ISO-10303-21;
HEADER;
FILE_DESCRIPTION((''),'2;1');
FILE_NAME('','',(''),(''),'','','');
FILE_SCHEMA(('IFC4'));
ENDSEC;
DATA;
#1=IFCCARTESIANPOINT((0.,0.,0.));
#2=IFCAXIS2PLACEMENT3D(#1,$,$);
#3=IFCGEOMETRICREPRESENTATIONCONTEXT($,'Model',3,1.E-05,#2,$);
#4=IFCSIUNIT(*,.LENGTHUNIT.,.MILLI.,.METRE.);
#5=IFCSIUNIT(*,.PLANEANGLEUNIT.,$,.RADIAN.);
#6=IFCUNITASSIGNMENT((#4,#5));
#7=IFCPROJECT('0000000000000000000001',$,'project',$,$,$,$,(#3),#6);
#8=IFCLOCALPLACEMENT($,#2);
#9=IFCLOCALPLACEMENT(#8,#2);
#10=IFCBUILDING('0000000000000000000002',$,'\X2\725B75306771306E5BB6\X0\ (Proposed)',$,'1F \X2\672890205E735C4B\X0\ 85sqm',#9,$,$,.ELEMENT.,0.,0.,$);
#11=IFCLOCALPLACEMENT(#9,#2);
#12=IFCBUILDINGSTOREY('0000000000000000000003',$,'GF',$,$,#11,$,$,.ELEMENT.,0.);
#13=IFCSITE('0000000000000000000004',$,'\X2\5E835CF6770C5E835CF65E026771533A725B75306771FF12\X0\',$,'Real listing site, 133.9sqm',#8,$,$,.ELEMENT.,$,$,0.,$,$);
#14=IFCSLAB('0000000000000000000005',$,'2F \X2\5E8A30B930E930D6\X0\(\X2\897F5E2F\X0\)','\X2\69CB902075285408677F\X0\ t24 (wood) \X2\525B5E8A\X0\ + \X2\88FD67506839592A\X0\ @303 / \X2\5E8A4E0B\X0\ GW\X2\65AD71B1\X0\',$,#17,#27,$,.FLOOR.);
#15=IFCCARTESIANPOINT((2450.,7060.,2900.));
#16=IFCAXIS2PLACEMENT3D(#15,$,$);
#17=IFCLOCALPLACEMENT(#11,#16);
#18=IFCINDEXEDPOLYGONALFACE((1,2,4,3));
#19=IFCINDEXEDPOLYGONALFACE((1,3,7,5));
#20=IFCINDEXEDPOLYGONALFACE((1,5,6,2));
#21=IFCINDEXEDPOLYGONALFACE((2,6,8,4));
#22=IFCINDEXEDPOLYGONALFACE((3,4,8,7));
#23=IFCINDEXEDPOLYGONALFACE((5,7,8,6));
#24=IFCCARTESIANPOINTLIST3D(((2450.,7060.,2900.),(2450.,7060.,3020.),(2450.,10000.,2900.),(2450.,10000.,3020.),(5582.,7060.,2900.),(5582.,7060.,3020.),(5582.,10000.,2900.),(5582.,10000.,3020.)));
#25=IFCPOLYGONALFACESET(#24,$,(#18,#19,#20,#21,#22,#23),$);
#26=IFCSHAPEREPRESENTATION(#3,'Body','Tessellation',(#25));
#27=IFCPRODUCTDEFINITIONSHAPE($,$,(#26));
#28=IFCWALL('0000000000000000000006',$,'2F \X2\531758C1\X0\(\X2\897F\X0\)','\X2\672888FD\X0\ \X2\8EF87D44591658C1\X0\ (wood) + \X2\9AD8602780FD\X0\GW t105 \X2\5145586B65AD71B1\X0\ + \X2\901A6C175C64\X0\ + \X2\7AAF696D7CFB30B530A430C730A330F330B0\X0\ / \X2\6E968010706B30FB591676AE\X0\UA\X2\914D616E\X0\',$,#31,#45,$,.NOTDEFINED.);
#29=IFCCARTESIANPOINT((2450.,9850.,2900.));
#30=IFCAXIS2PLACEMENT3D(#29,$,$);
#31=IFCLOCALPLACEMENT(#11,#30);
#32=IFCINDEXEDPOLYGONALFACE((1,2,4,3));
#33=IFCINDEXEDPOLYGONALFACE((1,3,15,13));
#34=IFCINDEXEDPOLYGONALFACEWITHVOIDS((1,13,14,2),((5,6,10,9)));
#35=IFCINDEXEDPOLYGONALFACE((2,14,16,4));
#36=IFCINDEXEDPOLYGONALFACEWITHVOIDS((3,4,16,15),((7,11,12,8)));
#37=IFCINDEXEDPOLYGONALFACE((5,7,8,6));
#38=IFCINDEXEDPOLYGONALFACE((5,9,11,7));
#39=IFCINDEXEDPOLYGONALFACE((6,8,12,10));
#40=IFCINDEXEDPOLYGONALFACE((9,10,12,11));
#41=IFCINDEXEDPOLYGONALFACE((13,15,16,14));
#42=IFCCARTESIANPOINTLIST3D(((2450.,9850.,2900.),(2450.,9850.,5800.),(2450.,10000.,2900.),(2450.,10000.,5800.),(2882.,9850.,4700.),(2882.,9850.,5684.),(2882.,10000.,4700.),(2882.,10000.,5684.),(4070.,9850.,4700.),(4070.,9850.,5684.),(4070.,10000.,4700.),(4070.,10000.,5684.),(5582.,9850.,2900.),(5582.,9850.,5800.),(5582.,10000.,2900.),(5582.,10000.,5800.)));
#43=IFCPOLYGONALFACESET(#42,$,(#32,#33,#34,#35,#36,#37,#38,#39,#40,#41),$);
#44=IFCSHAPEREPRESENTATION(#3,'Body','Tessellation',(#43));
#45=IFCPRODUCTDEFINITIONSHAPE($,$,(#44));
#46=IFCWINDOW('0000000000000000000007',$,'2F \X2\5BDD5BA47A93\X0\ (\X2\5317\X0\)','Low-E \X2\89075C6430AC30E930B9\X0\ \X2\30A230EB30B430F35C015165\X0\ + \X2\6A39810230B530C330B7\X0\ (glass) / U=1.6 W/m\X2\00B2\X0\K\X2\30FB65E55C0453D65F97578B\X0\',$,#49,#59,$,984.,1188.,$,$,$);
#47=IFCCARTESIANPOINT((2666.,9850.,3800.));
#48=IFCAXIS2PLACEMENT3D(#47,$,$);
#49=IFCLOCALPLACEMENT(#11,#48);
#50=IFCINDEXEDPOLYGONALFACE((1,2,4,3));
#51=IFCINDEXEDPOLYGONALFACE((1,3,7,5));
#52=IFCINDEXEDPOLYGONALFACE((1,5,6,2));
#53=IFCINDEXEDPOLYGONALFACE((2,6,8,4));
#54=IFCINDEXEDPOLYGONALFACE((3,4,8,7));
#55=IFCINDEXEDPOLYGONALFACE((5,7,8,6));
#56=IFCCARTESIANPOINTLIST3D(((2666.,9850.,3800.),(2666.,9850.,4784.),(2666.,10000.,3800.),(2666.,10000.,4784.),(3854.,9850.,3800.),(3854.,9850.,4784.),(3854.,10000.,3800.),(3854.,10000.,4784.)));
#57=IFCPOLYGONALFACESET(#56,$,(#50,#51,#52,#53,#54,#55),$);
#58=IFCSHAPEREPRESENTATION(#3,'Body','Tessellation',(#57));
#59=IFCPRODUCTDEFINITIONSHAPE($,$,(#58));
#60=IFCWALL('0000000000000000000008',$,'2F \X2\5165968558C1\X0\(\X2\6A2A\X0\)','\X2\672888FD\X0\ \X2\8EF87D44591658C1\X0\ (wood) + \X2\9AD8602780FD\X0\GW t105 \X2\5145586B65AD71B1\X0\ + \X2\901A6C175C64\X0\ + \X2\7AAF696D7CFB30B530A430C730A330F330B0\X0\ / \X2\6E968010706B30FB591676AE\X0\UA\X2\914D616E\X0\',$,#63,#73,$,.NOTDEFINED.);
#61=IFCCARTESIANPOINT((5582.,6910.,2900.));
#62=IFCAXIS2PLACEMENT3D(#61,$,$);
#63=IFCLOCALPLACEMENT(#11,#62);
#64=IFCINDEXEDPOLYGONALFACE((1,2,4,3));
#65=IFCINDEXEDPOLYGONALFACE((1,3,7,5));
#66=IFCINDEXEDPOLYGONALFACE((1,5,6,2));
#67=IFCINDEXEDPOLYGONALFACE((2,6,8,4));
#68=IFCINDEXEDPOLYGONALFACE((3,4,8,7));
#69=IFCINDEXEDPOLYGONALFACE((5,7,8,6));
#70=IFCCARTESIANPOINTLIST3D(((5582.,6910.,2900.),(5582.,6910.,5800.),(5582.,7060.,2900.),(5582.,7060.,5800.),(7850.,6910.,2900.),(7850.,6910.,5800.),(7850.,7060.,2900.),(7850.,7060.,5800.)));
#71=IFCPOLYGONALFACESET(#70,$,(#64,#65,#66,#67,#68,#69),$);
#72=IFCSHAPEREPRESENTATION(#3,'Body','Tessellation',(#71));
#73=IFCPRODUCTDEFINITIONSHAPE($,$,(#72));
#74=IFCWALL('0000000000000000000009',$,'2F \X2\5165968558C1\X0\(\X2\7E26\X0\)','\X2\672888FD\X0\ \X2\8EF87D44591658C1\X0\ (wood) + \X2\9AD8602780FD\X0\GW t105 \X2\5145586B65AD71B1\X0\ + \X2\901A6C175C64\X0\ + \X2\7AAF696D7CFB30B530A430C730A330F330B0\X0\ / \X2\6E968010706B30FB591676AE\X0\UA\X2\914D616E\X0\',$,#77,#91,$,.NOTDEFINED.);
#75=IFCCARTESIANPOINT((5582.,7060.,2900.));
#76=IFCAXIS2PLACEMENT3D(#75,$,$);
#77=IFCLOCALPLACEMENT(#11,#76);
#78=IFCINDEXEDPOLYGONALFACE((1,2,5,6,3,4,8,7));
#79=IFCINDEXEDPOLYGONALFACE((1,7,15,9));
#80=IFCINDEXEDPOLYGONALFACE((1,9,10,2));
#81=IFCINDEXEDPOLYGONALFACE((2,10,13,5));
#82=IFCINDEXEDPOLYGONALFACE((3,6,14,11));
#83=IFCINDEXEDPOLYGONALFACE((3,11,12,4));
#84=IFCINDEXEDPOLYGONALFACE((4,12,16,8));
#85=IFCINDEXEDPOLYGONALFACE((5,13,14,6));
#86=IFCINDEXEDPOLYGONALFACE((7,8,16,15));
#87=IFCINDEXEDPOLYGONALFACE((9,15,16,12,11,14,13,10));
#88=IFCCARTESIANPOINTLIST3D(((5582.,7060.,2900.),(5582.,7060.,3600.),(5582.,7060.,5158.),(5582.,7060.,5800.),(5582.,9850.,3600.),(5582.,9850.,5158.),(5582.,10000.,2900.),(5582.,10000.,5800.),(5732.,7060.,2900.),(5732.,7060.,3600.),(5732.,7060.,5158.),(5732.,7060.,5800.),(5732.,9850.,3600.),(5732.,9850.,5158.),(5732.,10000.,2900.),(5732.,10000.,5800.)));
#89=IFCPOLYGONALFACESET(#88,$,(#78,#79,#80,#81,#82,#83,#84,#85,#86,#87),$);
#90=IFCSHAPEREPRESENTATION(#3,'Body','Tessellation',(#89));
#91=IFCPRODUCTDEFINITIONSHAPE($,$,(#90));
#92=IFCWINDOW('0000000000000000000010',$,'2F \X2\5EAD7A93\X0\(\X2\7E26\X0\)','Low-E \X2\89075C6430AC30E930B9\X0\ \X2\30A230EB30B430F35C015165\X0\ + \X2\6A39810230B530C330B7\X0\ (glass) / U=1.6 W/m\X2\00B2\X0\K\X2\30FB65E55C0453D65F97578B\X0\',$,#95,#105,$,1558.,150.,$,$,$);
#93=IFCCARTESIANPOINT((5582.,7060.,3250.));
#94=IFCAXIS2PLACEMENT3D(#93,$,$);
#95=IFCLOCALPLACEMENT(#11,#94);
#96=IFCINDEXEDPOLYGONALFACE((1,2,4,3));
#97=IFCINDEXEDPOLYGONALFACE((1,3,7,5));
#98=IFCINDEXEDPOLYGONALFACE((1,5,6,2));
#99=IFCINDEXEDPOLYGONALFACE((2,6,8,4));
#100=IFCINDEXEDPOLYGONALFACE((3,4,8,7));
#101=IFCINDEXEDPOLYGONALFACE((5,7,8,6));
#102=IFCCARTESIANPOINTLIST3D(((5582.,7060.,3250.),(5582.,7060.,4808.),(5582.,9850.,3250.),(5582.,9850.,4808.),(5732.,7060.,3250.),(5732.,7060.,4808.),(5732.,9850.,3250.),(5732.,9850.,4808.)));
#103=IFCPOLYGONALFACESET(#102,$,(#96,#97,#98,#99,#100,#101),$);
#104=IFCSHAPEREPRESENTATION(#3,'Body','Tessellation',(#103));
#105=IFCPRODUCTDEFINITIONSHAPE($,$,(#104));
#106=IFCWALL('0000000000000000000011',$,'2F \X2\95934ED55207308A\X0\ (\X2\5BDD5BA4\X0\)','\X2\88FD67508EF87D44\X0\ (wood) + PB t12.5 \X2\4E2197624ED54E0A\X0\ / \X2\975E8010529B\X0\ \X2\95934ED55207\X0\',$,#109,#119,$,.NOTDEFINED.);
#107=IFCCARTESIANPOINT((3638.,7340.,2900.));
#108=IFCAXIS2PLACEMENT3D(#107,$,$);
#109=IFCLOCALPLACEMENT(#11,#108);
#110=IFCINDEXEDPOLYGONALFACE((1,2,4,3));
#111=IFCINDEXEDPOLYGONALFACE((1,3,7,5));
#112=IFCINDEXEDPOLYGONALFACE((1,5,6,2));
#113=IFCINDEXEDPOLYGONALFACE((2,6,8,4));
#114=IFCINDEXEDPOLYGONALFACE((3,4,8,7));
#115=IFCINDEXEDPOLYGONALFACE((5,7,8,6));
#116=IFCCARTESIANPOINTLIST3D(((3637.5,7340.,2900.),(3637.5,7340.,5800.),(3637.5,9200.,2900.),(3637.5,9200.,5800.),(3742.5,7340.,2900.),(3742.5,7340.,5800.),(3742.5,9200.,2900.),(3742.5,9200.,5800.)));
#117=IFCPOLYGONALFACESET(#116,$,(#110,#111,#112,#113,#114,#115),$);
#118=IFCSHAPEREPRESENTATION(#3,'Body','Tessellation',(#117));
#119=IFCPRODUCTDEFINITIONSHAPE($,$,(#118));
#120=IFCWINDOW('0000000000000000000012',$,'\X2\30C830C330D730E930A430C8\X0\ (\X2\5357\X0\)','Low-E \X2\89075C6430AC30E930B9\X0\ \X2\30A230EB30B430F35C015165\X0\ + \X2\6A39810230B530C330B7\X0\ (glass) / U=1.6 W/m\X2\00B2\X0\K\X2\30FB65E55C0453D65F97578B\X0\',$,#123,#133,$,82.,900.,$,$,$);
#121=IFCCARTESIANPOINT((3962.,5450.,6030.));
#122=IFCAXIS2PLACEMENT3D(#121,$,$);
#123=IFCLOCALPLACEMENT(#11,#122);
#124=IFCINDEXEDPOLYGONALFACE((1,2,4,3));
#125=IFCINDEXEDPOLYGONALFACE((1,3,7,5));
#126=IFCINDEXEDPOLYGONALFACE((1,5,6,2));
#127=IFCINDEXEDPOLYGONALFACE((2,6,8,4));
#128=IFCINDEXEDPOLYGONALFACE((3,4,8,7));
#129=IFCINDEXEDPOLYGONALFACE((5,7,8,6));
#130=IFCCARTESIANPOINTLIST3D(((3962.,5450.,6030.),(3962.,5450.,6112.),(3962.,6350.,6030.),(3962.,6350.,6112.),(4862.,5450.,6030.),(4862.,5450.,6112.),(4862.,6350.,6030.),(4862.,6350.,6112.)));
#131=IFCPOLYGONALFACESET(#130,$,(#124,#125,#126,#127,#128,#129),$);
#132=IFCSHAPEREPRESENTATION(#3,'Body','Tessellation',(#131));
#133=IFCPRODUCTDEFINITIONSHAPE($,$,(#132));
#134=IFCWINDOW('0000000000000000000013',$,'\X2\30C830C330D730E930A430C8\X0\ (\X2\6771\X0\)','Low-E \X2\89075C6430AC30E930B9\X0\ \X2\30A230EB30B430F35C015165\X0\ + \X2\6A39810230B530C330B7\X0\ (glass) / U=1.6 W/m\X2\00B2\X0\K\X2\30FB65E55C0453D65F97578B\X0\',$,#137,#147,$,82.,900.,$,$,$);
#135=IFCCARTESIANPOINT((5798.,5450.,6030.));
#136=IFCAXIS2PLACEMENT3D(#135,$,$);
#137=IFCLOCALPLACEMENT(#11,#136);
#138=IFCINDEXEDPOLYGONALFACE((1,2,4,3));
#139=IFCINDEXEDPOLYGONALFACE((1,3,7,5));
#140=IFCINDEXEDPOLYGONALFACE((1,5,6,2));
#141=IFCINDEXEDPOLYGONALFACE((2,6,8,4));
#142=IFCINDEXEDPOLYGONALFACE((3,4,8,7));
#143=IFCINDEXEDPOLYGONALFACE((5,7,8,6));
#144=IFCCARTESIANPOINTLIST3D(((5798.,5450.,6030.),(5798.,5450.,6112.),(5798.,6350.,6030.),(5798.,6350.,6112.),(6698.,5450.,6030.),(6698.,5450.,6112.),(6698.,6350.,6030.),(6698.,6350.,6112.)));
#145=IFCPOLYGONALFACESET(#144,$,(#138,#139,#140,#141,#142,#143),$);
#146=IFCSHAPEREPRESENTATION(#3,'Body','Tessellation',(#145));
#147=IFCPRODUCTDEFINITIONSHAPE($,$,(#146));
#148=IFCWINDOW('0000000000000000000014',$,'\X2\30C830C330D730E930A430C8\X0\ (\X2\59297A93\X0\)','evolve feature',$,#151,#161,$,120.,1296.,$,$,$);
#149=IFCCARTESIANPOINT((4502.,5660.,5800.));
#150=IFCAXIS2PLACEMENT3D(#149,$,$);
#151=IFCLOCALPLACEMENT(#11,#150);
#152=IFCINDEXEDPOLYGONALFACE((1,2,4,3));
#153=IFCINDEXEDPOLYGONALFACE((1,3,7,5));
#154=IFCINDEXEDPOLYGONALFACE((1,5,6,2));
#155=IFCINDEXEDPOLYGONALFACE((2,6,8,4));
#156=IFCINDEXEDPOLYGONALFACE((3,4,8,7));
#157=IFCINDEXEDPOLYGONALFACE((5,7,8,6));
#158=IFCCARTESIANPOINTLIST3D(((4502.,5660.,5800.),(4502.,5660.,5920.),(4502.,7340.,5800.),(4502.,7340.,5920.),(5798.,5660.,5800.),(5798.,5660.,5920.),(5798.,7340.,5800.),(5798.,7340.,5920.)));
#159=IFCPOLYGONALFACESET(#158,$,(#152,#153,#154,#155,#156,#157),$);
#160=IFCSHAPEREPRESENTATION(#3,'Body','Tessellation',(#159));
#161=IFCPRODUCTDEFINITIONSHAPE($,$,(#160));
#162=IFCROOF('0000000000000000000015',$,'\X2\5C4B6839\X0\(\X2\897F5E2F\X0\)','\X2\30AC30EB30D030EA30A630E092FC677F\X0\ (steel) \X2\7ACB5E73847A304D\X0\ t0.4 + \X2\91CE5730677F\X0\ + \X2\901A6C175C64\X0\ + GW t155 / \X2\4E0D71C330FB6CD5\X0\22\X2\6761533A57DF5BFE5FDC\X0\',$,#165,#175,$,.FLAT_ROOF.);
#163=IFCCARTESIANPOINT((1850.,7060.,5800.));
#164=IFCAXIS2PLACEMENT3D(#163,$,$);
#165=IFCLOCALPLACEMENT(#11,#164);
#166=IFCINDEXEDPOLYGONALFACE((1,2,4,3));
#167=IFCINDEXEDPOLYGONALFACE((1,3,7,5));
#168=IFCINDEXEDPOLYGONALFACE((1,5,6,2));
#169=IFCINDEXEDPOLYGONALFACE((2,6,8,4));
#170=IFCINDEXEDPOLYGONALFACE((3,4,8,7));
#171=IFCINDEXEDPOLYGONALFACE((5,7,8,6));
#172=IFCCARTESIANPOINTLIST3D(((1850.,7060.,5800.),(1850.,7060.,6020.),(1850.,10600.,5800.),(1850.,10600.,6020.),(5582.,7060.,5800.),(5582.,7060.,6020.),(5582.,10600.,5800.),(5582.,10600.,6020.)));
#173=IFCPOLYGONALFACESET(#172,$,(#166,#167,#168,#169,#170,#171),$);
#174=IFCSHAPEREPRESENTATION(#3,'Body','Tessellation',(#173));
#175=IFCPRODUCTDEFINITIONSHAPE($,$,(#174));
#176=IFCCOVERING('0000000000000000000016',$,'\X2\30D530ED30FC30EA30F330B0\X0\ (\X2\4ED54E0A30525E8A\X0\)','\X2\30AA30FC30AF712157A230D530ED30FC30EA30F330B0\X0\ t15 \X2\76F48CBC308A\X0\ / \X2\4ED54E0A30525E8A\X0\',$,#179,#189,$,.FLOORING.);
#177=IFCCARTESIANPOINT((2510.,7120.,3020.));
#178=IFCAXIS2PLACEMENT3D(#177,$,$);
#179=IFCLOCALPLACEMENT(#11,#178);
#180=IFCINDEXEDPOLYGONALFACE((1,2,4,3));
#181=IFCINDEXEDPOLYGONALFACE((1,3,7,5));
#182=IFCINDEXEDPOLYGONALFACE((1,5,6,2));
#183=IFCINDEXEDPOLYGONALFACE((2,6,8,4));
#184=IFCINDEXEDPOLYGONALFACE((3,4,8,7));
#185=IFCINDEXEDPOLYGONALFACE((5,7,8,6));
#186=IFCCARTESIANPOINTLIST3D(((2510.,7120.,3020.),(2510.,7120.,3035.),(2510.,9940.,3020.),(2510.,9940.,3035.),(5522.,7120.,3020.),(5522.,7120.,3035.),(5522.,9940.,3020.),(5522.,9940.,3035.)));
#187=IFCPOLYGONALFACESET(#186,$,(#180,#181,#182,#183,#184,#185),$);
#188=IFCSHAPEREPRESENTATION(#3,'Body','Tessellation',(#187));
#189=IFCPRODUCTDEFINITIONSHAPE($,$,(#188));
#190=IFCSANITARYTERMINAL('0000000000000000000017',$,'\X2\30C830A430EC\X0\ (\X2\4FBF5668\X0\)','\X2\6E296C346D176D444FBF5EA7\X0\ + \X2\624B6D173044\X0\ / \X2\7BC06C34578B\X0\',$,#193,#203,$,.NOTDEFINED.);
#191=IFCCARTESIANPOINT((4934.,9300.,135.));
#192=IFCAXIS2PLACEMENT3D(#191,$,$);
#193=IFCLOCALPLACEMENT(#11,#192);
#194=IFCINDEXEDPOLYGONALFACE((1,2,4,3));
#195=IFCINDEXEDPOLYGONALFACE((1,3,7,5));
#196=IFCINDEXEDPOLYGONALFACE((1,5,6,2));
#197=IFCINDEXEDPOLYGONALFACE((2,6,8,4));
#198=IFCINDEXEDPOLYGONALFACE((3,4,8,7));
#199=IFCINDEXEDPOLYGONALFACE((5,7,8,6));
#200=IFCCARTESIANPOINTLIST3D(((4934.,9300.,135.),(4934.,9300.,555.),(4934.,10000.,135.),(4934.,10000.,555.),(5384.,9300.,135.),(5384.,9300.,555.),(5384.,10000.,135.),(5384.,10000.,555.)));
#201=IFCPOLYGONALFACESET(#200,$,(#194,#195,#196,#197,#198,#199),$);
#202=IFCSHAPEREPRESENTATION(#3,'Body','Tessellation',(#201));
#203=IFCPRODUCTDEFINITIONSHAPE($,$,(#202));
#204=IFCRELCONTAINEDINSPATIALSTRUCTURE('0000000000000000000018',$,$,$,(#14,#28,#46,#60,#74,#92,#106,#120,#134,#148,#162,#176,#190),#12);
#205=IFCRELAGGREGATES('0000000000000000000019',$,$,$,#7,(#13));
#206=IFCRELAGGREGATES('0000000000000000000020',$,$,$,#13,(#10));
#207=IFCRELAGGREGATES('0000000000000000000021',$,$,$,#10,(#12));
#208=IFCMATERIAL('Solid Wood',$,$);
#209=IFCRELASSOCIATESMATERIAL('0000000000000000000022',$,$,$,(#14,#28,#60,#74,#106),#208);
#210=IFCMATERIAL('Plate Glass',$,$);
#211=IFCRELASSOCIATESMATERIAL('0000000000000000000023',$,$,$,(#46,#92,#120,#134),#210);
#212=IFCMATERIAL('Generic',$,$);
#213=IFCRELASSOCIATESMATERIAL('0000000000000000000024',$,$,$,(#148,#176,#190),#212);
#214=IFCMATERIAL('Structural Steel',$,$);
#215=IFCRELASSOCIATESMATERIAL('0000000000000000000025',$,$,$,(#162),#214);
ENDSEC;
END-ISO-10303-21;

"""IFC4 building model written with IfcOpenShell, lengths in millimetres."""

from ifc_helpers import new_model, si_unit, frame, frame_2d, origin, place, context, project, spatial, rectangle, extrude, material, element, fill, save


model = new_model("IFC4")

# Units and contexts
model_context = context("Model", 3, precision=1e-05, world=origin())
ifc_project = project(units=[si_unit("LENGTHUNIT", "METRE", prefix="MILLI"), si_unit("PLANEANGLEUNIT", "RADIAN")], contexts=[model_context])

# Site, building, storey
site_placement = place(None, origin())
site = spatial("IfcSite", under=ifc_project, at=site_placement, Name="広島県広島市東区牛田東２", ObjectType="Real listing site, 133.9sqm", CompositionType="ELEMENT", RefElevation=0.0)
building_placement = place(site_placement, origin())
building = spatial("IfcBuilding", under=site, at=building_placement, Name="牛田東の家 (Proposed)", ObjectType="1F 木造平屋 85sqm", CompositionType="ELEMENT", ElevationOfRefHeight=0.0, ElevationOfTerrain=0.0)
storey_placement = place(building_placement, origin())
storey = spatial("IfcBuildingStorey", under=building, at=storey_placement, Name="GF", CompositionType="ELEMENT", Elevation=0.0)

# Slab
ifc_material_1 = material(Name="Solid Wood")
slab_placement = place(storey_placement, frame((2450.0, 7060.0, 2900.0)))
element("IfcSlab", 1, at=slab_placement, inside=storey, material=ifc_material_1, Name="2F 床スラブ(西帯)", Description="構造用合板 t24 (wood) 剛床 + 製材根太 @303 / 床下 GW断熱", PredefinedType="FLOOR", context=model_context, shape_type="SweptSolid", body=[
    extrude(rectangle(XDim=3132.0, YDim=2940.0, at=frame_2d((1566.0, 1470.0))), frame((2450.0, 7060.0, 2900.0)), (0.0, 0.0, 1.0), 120.0),
])

# Wall, opening, window
wall_1_placement = place(storey_placement, frame((2450.0, 9850.0, 2900.0)))
wall_1 = element("IfcWall", 2, at=wall_1_placement, inside=storey, material=ifc_material_1, Name="2F 北壁(西)", Description="木製 軸組外壁 (wood) + 高性能GW t105 充填断熱 + 通気層 + 窯業系サイディング / 準耐火・外皮UA配慮", PredefinedType="NOTDEFINED", context=model_context, shape_type="SweptSolid", body=[
    extrude(rectangle(XDim=3132.0, YDim=150.0, at=frame_2d((1566.0, 75.0))), frame((2450.0, 9850.0, 2900.0)), (0.0, 0.0, 1.0), 2900.0),
])
opening_1_placement = place(storey_placement, frame((2666.0, 9850.0, 3800.0)))
opening_1 = element("IfcOpeningElement", 3, at=opening_1_placement, cuts=wall_1, PredefinedType="NOTDEFINED", context=model_context, shape_type="SweptSolid", body=[
    extrude(rectangle(XDim=1188.0, YDim=150.0, at=frame_2d((594.0, 75.0))), frame((2666.0, 9850.0, 3800.0)), (0.0, 0.0, 1.0), 984.0),
])
ifc_material_2 = material(Name="Plate Glass")
window_1_placement = place(storey_placement, frame((2666.0, 9850.0, 3800.0)))
window_1 = element("IfcWindow", 4, at=window_1_placement, inside=storey, material=ifc_material_2, Name="2F 寝室窓 (北)", Description="Low-E 複層ガラス アルゴン封入 + 樹脂サッシ (glass) / U=1.6 W/m²K・日射取得型", OverallHeight=984.0, OverallWidth=1188.0, context=model_context, shape_type="SweptSolid", body=[
    extrude(rectangle(XDim=1188.0, YDim=150.0, at=frame_2d((594.0, 75.0))), frame((2666.0, 9850.0, 3800.0)), (0.0, 0.0, 1.0), 984.0),
])
fill(opening_1, window_1)

# Wall
wall_2_placement = place(storey_placement, frame((5582.0, 6910.0, 2900.0)))
element("IfcWall", 5, at=wall_2_placement, inside=storey, material=ifc_material_1, Name="2F 入隅壁(横)", Description="木製 軸組外壁 (wood) + 高性能GW t105 充填断熱 + 通気層 + 窯業系サイディング / 準耐火・外皮UA配慮", PredefinedType="NOTDEFINED", context=model_context, shape_type="SweptSolid", body=[
    extrude(rectangle(XDim=2268.0, YDim=150.0, at=frame_2d((1134.0, 75.0))), frame((5582.0, 6910.0, 2900.0)), (0.0, 0.0, 1.0), 2900.0),
])

# Wall, opening, window
wall_3_placement = place(storey_placement, frame((5582.0, 7060.0, 2900.0)))
wall_3 = element("IfcWall", 6, at=wall_3_placement, inside=storey, material=ifc_material_1, Name="2F 入隅壁(縦)", Description="木製 軸組外壁 (wood) + 高性能GW t105 充填断熱 + 通気層 + 窯業系サイディング / 準耐火・外皮UA配慮", PredefinedType="NOTDEFINED", context=model_context, shape_type="SweptSolid", body=[
    extrude(rectangle(XDim=150.0, YDim=2940.0, at=frame_2d((75.0, 1470.0))), frame((5582.0, 7060.0, 2900.0)), (0.0, 0.0, 1.0), 2900.0),
])
opening_2_placement = place(storey_placement, frame((5582.0, 7060.0, 3250.0)))
opening_2 = element("IfcOpeningElement", 7, at=opening_2_placement, cuts=wall_3, PredefinedType="NOTDEFINED", context=model_context, shape_type="SweptSolid", body=[
    extrude(rectangle(XDim=150.0, YDim=2790.0, at=frame_2d((75.0, 1395.0))), frame((5582.0, 7060.0, 3250.0)), (0.0, 0.0, 1.0), 1558.0),
])
window_2_placement = place(storey_placement, frame((5582.0, 7060.0, 3250.0)))
window_2 = element("IfcWindow", 8, at=window_2_placement, inside=storey, material=ifc_material_2, Name="2F 庭窓(縦)", Description="Low-E 複層ガラス アルゴン封入 + 樹脂サッシ (glass) / U=1.6 W/m²K・日射取得型", OverallHeight=1558.0, OverallWidth=150.0, context=model_context, shape_type="SweptSolid", body=[
    extrude(rectangle(XDim=150.0, YDim=2790.0, at=frame_2d((75.0, 1395.0))), frame((5582.0, 7060.0, 3250.0)), (0.0, 0.0, 1.0), 1558.0),
])
fill(opening_2, window_2)

# Wall
wall_4_placement = place(storey_placement, frame((3638.0, 7340.0, 2900.0)))
element("IfcWall", 9, at=wall_4_placement, inside=storey, material=ifc_material_1, Name="2F 間仕切り (寝室)", Description="製材軸組 (wood) + PB t12.5 両面仕上 / 非耐力 間仕切", PredefinedType="NOTDEFINED", context=model_context, shape_type="SweptSolid", body=[
    extrude(rectangle(XDim=105.0, YDim=1860.0, at=frame_2d((52.0, 930.0))), frame((3638.0, 7340.0, 2900.0)), (0.0, 0.0, 1.0), 2900.0),
])

# Windows
window_3_placement = place(storey_placement, frame((3962.0, 5450.0, 6030.0)))
element("IfcWindow", 10, at=window_3_placement, inside=storey, material=ifc_material_2, Name="トップライト (南)", Description="Low-E 複層ガラス アルゴン封入 + 樹脂サッシ (glass) / U=1.6 W/m²K・日射取得型", OverallHeight=82.0, OverallWidth=900.0, context=model_context, shape_type="SweptSolid", body=[
    extrude(rectangle(XDim=900.0, YDim=900.0, at=frame_2d((450.0, 450.0))), frame((3962.0, 5450.0, 6030.0)), (0.0, 0.0, 1.0), 82.0),
])
window_4_placement = place(storey_placement, frame((5798.0, 5450.0, 6030.0)))
element("IfcWindow", 11, at=window_4_placement, inside=storey, material=ifc_material_2, Name="トップライト (東)", Description="Low-E 複層ガラス アルゴン封入 + 樹脂サッシ (glass) / U=1.6 W/m²K・日射取得型", OverallHeight=82.0, OverallWidth=900.0, context=model_context, shape_type="SweptSolid", body=[
    extrude(rectangle(XDim=900.0, YDim=900.0, at=frame_2d((450.0, 450.0))), frame((5798.0, 5450.0, 6030.0)), (0.0, 0.0, 1.0), 82.0),
])
ifc_material_3 = material(Name="Generic")
window_5_placement = place(storey_placement, frame((4502.0, 5660.0, 5800.0)))
element("IfcWindow", 12, at=window_5_placement, inside=storey, material=ifc_material_3, Name="トップライト (天窓)", Description="evolve feature", OverallHeight=120.0, OverallWidth=1296.0, context=model_context, shape_type="SweptSolid", body=[
    extrude(rectangle(XDim=1296.0, YDim=1680.0, at=frame_2d((648.0, 840.0))), frame((4502.0, 5660.0, 5800.0)), (0.0, 0.0, 1.0), 120.0),
])

# Roof
ifc_material_4 = material(Name="Structural Steel")
for number, where, name in (
    (13, (1850.0, 7060.0, 5800.0), "屋根(西帯)"),
):
    element("IfcRoof", number, at=place(storey_placement, frame(where)), inside=storey, material=ifc_material_4, Name=name, Description="ガルバリウム鋼板 (steel) 立平葺き t0.4 + 野地板 + 通気層 + GW t155 / 不燃・法22条区域対応", PredefinedType="FLAT_ROOF", context=model_context, shape_type="SweptSolid", body=[
        extrude(rectangle(XDim=3732.0, YDim=3540.0, at=frame_2d((1866.0, 1770.0))), frame((1850.0, 7060.0, 5800.0)), (0.0, 0.0, 1.0), 220.0),
    ])

# Covering
covering_placement = place(storey_placement, frame((2510.0, 7120.0, 3020.0)))
element("IfcCovering", 14, at=covering_placement, inside=storey, material=ifc_material_3, Name="フローリング (仕上げ床)", Description="オーク無垢フローリング t15 直貼り / 仕上げ床", PredefinedType="FLOORING", context=model_context, shape_type="SweptSolid", body=[
    extrude(rectangle(XDim=3012.0, YDim=2820.0, at=frame_2d((1506.0, 1410.0))), frame((2510.0, 7120.0, 3020.0)), (0.0, 0.0, 1.0), 15.0),
])

# Sanitary terminal
sanitary_terminal_placement = place(storey_placement, frame((4934.0, 9300.0, 135.0)))
element("IfcSanitaryTerminal", 15, at=sanitary_terminal_placement, inside=storey, material=ifc_material_3, Name="トイレ (便器)", Description="温水洗浄便座 + 手洗い / 節水型", PredefinedType="NOTDEFINED", context=model_context, shape_type="SweptSolid", body=[
    extrude(rectangle(XDim=450.0, YDim=700.0, at=frame_2d((225.0, 350.0))), frame((4934.0, 9300.0, 135.0)), (0.0, 0.0, 1.0), 420.0),
])

save(model, "model.ifc")
